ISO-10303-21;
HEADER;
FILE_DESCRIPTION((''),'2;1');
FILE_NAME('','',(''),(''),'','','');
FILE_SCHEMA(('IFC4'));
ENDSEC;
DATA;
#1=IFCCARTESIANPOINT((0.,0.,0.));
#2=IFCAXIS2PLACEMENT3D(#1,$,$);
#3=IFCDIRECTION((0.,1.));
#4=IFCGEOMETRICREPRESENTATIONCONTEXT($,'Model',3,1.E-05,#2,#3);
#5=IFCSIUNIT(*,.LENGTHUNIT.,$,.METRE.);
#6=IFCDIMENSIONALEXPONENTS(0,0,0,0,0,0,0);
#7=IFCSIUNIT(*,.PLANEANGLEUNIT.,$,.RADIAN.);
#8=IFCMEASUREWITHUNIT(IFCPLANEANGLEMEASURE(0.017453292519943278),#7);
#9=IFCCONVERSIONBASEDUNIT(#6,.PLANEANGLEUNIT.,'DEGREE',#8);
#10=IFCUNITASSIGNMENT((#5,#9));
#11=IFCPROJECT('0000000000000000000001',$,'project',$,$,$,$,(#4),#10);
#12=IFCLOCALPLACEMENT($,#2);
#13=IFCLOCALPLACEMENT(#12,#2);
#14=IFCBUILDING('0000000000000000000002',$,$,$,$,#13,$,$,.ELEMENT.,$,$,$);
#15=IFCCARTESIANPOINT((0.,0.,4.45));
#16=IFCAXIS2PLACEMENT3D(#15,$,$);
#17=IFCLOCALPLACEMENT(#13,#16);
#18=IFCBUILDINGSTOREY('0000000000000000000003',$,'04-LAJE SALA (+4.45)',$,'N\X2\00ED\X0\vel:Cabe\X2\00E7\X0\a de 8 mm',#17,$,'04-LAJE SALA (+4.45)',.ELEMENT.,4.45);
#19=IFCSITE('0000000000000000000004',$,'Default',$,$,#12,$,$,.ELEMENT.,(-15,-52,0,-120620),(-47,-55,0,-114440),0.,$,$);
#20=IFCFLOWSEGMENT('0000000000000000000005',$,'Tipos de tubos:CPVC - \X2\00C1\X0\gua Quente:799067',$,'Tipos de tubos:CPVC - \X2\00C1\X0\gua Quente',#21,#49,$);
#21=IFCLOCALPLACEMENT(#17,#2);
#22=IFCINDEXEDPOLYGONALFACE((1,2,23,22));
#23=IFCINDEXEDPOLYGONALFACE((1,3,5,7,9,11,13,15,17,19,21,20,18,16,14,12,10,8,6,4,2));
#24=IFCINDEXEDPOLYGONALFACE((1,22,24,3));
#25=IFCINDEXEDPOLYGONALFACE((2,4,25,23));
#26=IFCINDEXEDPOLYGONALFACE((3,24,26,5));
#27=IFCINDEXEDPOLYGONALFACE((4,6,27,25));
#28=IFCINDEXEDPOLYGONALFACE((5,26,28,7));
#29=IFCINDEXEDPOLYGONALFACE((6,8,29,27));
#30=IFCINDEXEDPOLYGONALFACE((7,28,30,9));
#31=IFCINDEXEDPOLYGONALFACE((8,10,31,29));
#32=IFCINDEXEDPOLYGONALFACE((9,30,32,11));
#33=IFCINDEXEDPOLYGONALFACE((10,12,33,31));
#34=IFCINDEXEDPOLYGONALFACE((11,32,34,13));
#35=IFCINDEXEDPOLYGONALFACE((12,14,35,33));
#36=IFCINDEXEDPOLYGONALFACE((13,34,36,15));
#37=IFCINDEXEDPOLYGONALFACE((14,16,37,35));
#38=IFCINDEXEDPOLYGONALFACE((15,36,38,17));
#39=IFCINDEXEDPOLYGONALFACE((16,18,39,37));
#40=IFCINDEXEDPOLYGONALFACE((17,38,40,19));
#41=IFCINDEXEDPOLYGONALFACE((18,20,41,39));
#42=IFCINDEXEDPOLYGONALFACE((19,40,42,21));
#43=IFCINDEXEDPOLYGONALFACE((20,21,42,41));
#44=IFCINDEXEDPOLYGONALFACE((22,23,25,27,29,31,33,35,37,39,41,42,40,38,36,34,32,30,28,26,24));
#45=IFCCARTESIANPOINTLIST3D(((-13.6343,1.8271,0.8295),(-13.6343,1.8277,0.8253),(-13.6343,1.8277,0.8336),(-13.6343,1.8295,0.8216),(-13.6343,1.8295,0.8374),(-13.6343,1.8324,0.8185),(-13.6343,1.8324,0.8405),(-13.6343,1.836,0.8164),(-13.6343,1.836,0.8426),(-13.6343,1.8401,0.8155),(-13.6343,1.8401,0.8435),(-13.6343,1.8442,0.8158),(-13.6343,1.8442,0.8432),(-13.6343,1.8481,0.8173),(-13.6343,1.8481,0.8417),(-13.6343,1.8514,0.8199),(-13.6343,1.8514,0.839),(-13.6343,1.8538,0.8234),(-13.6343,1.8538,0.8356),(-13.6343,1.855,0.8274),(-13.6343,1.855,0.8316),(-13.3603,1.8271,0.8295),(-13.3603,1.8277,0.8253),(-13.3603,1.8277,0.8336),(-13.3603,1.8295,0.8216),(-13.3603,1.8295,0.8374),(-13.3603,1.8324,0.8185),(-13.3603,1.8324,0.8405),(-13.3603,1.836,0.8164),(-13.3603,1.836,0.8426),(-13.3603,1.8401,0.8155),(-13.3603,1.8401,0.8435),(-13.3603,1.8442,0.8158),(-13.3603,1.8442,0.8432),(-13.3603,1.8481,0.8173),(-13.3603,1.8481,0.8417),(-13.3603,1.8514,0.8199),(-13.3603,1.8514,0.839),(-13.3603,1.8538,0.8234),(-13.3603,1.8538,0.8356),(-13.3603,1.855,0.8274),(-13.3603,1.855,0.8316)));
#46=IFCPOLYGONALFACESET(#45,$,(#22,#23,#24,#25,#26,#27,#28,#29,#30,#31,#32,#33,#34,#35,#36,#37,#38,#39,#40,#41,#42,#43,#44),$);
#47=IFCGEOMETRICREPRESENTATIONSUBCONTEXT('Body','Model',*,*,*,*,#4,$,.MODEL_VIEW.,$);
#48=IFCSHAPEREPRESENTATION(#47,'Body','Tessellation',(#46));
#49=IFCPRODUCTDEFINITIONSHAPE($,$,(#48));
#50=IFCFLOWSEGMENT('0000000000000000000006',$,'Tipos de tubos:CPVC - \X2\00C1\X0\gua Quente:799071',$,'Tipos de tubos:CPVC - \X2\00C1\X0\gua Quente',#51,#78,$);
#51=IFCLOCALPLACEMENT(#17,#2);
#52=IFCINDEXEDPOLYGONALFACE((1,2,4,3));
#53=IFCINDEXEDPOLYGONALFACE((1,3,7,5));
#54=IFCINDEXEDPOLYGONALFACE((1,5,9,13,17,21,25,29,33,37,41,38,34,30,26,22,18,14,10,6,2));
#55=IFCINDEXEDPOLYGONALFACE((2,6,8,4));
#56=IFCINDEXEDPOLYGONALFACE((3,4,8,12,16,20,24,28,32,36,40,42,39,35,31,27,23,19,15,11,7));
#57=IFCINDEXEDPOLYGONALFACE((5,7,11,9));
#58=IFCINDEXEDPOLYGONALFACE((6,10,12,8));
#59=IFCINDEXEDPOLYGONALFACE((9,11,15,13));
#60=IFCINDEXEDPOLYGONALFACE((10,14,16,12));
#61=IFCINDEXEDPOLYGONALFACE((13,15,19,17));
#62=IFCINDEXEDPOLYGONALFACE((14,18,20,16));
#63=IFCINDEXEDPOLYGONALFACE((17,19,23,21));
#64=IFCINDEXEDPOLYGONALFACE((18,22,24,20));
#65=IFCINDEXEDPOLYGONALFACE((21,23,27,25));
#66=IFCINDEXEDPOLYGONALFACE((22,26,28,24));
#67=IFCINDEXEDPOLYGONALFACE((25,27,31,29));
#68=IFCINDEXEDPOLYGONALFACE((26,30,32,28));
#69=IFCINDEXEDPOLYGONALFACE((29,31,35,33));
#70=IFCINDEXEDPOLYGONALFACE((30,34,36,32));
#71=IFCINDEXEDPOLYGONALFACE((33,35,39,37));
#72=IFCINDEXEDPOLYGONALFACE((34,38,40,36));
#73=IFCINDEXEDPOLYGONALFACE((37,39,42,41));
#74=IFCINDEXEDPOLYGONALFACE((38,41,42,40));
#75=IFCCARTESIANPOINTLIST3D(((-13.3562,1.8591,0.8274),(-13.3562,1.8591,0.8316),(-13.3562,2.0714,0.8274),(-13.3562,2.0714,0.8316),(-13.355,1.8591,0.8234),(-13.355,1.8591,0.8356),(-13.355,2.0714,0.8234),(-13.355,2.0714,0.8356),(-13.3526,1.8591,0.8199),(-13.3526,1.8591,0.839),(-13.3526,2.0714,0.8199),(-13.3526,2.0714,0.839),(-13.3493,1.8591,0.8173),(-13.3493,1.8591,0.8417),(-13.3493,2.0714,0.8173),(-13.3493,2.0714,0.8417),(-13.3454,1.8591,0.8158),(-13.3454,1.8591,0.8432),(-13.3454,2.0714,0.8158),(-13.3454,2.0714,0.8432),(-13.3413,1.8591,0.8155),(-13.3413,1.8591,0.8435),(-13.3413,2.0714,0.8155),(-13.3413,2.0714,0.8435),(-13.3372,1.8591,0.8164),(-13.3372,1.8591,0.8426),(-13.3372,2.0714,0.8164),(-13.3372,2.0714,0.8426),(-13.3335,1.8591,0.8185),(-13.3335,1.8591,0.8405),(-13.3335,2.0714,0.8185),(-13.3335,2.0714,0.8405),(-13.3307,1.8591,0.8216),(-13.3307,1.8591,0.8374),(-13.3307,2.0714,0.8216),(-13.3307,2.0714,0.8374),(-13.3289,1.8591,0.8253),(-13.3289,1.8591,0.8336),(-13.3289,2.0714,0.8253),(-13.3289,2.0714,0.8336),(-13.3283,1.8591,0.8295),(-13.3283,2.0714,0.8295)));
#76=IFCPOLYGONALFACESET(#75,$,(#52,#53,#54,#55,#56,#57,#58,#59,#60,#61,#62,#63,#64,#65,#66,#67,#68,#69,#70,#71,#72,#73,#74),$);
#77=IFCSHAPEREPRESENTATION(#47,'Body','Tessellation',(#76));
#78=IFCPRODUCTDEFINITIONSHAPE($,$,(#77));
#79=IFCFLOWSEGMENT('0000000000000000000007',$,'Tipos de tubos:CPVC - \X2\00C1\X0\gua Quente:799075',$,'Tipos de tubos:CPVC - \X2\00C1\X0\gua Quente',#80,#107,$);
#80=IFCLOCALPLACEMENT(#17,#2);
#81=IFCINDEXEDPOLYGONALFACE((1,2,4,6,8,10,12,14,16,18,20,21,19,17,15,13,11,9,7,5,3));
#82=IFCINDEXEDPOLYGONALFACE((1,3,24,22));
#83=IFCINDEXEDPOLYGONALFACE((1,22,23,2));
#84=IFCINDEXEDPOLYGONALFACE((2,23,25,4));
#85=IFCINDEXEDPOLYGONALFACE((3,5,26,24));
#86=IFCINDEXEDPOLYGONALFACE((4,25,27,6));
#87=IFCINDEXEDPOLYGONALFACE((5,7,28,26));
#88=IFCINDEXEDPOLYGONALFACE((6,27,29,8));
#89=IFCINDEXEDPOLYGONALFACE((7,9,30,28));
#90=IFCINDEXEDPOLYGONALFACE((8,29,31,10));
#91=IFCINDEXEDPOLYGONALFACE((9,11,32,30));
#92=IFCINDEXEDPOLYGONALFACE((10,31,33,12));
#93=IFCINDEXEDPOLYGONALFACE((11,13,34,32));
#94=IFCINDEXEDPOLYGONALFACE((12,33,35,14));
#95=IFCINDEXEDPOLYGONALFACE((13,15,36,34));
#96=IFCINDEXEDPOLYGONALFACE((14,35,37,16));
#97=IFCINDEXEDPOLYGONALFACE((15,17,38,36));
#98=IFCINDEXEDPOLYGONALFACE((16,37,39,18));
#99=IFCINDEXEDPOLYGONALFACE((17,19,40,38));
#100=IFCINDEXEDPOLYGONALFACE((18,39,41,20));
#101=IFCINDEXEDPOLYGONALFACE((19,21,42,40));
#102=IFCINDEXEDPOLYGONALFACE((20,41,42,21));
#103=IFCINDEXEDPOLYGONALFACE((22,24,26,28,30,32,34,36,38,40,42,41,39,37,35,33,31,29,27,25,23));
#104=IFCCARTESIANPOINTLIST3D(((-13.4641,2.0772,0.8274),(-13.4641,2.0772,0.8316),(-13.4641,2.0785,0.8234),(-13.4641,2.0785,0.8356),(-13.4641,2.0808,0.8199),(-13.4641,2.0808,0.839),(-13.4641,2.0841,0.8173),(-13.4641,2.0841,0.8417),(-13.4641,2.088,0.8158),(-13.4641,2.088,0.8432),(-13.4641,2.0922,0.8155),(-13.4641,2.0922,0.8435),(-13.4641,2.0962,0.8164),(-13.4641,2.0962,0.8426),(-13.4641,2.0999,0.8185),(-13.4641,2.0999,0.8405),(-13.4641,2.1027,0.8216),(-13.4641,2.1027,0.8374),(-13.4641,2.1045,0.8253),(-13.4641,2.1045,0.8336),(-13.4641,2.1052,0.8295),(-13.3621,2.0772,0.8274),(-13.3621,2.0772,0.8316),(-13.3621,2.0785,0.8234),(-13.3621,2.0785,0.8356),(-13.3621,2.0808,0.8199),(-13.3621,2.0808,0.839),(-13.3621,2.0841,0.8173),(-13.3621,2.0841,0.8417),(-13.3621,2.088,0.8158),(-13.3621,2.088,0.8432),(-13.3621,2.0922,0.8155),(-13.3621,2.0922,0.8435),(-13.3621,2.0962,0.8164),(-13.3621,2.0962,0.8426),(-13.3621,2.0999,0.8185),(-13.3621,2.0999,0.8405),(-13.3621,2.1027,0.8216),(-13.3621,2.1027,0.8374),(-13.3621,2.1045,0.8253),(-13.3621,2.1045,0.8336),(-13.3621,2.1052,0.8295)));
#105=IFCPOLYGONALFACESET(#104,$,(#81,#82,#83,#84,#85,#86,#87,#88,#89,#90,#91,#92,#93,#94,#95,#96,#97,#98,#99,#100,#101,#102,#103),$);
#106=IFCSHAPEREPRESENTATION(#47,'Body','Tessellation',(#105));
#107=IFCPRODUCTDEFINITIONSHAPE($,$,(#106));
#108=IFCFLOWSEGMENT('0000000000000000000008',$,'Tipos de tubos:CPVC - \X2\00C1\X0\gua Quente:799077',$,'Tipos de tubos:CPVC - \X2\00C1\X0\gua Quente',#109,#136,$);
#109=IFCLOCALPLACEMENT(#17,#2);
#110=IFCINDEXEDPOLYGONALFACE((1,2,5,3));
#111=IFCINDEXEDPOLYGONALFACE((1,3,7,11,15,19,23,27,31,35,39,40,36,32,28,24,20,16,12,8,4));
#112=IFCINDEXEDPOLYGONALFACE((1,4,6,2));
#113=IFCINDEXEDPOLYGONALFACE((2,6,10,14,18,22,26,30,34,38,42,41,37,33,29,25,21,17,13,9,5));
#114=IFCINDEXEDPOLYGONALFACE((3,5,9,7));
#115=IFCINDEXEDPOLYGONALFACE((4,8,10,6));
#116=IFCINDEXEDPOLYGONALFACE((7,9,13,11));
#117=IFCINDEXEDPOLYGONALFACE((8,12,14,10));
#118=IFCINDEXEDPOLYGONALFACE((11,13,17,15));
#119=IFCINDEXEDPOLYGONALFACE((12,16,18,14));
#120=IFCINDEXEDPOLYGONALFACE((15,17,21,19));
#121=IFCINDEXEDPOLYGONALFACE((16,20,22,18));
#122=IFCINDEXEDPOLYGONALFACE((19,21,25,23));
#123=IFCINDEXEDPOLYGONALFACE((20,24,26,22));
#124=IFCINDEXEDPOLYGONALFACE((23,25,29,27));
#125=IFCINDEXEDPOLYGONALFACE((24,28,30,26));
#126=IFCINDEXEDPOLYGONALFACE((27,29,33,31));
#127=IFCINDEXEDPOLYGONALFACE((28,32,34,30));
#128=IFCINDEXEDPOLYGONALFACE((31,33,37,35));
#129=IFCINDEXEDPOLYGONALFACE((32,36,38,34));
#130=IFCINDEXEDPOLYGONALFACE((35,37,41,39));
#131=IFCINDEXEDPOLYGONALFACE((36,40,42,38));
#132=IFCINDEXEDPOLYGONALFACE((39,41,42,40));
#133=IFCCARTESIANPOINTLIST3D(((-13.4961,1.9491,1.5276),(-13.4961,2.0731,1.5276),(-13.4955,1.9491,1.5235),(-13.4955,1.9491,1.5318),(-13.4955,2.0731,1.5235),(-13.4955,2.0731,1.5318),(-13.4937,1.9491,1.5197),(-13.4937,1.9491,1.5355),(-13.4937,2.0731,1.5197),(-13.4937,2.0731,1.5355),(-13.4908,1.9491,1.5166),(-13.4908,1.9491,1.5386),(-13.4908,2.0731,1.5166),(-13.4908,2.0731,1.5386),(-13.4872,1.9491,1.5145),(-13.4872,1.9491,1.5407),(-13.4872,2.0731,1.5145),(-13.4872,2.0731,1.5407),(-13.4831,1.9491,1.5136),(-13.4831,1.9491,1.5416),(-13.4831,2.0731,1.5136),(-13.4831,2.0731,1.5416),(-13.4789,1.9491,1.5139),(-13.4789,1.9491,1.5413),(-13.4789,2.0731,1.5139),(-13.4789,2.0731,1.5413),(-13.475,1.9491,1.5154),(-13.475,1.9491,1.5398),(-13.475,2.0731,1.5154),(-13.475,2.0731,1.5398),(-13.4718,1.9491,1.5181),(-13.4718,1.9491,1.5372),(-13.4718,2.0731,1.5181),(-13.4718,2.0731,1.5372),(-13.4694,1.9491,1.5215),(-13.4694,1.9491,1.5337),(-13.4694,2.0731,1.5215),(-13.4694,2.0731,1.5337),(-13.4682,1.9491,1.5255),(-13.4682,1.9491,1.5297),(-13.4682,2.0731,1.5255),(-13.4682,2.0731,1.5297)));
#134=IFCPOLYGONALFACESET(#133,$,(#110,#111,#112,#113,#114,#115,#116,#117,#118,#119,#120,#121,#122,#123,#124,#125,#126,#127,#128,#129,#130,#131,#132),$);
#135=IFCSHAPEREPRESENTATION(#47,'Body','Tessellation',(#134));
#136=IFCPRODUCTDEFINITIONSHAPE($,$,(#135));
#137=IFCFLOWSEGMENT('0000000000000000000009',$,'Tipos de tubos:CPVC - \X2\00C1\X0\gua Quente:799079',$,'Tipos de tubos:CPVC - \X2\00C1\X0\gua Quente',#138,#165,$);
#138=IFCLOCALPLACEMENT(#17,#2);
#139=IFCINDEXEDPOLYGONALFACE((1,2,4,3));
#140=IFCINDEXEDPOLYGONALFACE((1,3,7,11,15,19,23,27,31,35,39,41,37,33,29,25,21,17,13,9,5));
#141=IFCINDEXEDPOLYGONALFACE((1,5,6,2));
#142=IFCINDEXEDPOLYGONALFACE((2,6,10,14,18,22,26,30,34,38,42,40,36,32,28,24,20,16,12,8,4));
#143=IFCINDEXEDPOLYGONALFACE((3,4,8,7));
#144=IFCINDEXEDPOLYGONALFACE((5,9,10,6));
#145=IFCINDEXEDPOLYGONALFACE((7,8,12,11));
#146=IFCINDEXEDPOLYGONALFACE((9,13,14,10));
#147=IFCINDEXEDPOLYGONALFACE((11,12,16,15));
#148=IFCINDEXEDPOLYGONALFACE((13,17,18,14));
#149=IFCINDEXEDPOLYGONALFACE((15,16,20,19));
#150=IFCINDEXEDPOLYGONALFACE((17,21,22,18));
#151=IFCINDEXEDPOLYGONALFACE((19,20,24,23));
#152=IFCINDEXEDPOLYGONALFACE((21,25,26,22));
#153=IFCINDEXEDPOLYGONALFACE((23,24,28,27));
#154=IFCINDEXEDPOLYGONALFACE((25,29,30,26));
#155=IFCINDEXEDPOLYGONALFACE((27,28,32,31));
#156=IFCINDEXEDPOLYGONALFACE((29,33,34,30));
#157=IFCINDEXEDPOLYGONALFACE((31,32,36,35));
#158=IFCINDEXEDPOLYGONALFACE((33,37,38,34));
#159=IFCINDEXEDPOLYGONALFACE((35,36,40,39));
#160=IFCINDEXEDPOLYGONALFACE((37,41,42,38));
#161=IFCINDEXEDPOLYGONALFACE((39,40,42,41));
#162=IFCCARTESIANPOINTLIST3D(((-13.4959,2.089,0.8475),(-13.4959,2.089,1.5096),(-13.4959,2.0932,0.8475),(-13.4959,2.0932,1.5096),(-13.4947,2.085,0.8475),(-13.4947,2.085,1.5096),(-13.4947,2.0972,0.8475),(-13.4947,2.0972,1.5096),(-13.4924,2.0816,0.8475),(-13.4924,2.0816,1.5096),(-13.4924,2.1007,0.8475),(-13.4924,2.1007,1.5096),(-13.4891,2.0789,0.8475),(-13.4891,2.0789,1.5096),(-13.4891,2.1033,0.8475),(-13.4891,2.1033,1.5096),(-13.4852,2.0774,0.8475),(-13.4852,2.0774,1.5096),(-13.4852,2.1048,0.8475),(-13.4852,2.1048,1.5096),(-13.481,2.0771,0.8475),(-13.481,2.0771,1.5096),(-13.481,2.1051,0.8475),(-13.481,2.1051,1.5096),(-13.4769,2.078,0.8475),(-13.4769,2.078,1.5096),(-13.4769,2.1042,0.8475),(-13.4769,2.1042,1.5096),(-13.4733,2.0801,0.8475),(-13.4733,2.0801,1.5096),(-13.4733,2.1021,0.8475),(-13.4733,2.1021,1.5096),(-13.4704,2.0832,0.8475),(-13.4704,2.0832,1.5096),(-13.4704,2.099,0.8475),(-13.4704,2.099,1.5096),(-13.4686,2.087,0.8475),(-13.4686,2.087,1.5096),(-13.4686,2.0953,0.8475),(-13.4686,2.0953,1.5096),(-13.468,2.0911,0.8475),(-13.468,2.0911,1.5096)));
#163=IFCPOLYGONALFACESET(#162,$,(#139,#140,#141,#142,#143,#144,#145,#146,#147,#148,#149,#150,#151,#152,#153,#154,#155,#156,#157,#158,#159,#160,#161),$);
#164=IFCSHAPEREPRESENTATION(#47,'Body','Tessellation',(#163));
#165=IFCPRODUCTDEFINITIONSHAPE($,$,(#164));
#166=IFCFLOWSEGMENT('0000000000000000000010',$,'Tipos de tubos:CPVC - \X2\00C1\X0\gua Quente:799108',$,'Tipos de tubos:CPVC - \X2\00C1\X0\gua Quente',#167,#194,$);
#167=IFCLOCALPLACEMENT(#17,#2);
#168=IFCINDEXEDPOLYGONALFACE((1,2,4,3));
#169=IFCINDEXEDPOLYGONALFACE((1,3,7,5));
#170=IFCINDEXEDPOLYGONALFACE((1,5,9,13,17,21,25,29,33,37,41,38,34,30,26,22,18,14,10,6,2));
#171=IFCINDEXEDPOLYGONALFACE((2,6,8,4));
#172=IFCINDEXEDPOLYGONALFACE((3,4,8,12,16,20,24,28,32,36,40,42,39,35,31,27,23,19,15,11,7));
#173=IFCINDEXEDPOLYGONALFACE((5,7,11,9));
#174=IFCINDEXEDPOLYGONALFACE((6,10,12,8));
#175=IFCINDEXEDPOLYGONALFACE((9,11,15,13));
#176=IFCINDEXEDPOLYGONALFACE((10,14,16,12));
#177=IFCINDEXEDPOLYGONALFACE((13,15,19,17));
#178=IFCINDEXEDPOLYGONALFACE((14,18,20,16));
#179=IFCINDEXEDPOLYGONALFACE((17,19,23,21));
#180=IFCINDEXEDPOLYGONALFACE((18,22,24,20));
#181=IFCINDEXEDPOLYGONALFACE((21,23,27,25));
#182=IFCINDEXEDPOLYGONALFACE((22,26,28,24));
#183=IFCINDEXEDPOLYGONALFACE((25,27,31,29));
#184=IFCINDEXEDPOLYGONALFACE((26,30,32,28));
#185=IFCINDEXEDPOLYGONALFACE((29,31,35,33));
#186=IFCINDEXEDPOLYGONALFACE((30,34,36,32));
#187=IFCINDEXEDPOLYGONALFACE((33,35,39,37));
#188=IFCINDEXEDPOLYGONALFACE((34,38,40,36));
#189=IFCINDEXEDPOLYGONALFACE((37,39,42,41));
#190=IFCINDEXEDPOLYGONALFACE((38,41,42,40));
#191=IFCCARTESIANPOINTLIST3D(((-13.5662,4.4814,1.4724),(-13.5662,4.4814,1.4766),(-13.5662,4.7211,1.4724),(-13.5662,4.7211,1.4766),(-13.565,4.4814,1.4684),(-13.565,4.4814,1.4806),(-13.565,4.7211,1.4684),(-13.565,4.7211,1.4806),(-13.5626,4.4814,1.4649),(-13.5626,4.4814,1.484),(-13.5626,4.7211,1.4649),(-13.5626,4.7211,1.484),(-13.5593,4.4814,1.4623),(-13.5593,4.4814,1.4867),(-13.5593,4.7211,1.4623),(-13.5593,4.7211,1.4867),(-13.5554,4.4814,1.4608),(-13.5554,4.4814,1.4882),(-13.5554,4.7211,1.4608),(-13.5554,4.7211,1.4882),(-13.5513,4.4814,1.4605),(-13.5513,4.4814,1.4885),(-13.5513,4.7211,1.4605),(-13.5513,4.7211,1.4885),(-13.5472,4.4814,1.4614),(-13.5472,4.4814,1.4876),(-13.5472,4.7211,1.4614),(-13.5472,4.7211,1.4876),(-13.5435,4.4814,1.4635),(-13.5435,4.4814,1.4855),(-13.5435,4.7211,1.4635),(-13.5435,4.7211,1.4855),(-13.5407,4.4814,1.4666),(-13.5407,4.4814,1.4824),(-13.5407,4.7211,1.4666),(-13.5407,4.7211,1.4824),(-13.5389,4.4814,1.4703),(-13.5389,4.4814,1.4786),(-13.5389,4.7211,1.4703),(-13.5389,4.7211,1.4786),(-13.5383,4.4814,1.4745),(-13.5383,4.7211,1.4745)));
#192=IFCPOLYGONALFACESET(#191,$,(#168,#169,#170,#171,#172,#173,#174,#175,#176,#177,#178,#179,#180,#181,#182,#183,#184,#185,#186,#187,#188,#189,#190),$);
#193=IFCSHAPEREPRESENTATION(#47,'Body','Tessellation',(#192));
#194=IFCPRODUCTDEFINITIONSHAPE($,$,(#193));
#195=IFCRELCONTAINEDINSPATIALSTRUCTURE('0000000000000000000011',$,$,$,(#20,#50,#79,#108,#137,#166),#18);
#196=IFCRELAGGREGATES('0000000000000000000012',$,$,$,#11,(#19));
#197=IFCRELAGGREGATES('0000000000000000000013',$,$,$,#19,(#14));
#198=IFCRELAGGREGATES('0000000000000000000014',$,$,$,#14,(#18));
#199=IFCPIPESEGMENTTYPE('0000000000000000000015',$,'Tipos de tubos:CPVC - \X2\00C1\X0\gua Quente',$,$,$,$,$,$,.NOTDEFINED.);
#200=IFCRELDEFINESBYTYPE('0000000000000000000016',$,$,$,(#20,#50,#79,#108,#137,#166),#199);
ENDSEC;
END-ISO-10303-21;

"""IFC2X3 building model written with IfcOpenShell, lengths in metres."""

from ifc_helpers import new_model, entity, si_unit, converted_unit, direction, frame, frame_2d, origin, origin_2d_with_axis, place, context, subcontext, project, spatial, circle, extrude, type_object, element, save


model = new_model("IFC2X3")

# Units and contexts
model_context = context("Model", 3, precision=1e-05, world=origin(), true_north=direction((0.0, 1.0)))
body_context = subcontext(model_context, "Body", "Model", "MODEL_VIEW")
ifc_project = project(units=[si_unit("LENGTHUNIT", "METRE"), converted_unit("PLANEANGLEUNIT", "DEGREE", entity("IfcPlaneAngleMeasure", 0.017453292519943278), si_unit("PLANEANGLEUNIT", "RADIAN"), dimensions=[0, 0, 0, 0, 0, 0, 0])], contexts=[model_context])

# Site, building, storey
site_placement = place(None, origin())
site = spatial("IfcSite", under=ifc_project, at=site_placement, Name="Default", CompositionType="ELEMENT", RefLatitude=(-15, -52, 0, -120620), RefLongitude=(-47, -55, 0, -114440), RefElevation=0.0)
building_placement = place(site_placement, origin())
building = spatial("IfcBuilding", under=site, at=building_placement, CompositionType="ELEMENT")
storey_placement = place(building_placement, frame((0.0, 0.0, 4.45)))
storey = spatial("IfcBuildingStorey", under=building, at=storey_placement, Name="04-LAJE SALA (+4.45)", ObjectType="Nível:Cabeça de 8 mm", LongName="04-LAJE SALA (+4.45)", CompositionType="ELEMENT", Elevation=4.45)

# Flow segments
pipe_segment_type_1 = type_object("IfcPipeSegmentType", Name="Tipos de tubos:CPVC - Água Quente", PredefinedType="NOTDEFINED")
flow_segment_1_placement = place(storey_placement, origin())
element("IfcFlowSegment", 1, at=flow_segment_1_placement, inside=storey, type_object=pipe_segment_type_1, Name="Tipos de tubos:CPVC - Água Quente:799067", ObjectType="Tipos de tubos:CPVC - Água Quente", context=body_context, shape_type="SweptSolid", body=[
    extrude(circle(Radius=0.0141, at=frame_2d((0.0, 0.0), x_axis=(1.0, 0.0))), frame((-13.6343, 1.8411, 0.8295), z_axis=(1.0, 0.0, 0.0), x_axis=(0.0, -1.0, 0.0)), (0.0, 0.0, 1.0), 0.274),
])
flow_segment_2_placement = place(storey_placement, origin())
element("IfcFlowSegment", 2, at=flow_segment_2_placement, inside=storey, type_object=pipe_segment_type_1, Name="Tipos de tubos:CPVC - Água Quente:799071", ObjectType="Tipos de tubos:CPVC - Água Quente", context=body_context, shape_type="SweptSolid", body=[
    extrude(circle(Radius=0.0141, at=frame_2d((0.0, 0.0), x_axis=(1.0, 0.0))), frame((-13.3423, 1.8591, 0.8295), z_axis=(0.0, 1.0, 0.0), x_axis=(1.0, 0.0, 0.0)), (0.0, 0.0, 1.0), 0.2122),
])
flow_segment_3_placement = place(storey_placement, origin())
element("IfcFlowSegment", 3, at=flow_segment_3_placement, inside=storey, type_object=pipe_segment_type_1, Name="Tipos de tubos:CPVC - Água Quente:799075", ObjectType="Tipos de tubos:CPVC - Água Quente", context=body_context, shape_type="SweptSolid", body=[
    extrude(circle(Radius=0.0141, at=frame_2d((0.0, 0.0), x_axis=(1.0, 0.0))), frame((-13.4641, 2.0911, 0.8295), z_axis=(1.0, 0.0, 0.0), x_axis=(0.0, 1.0, 0.0)), (0.0, 0.0, 1.0), 0.102),
])
flow_segment_4_placement = place(storey_placement, origin())
element("IfcFlowSegment", 4, at=flow_segment_4_placement, inside=storey, type_object=pipe_segment_type_1, Name="Tipos de tubos:CPVC - Água Quente:799077", ObjectType="Tipos de tubos:CPVC - Água Quente", context=body_context, shape_type="SweptSolid", body=[
    extrude(circle(Radius=0.0141, at=origin_2d_with_axis()), frame((-13.4821, 1.9491, 1.5276), z_axis=(0.0, 1.0, 0.0), x_axis=(-1.0, 0.0, 0.0)), (0.0, 0.0, 1.0), 0.124),
])
flow_segment_5_placement = place(storey_placement, origin())
element("IfcFlowSegment", 5, at=flow_segment_5_placement, inside=storey, type_object=pipe_segment_type_1, Name="Tipos de tubos:CPVC - Água Quente:799079", ObjectType="Tipos de tubos:CPVC - Água Quente", context=body_context, shape_type="SweptSolid", body=[
    extrude(circle(Radius=0.0141, at=origin_2d_with_axis()), frame((-13.4821, 2.0911, 0.8475)), (0.0, 0.0, 1.0), 0.6621),
])
flow_segment_6_placement = place(storey_placement, origin())
element("IfcFlowSegment", 6, at=flow_segment_6_placement, inside=storey, type_object=pipe_segment_type_1, Name="Tipos de tubos:CPVC - Água Quente:799108", ObjectType="Tipos de tubos:CPVC - Água Quente", context=body_context, shape_type="SweptSolid", body=[
    extrude(circle(Radius=0.0141, at=frame_2d((0.0, 0.0), x_axis=(1.0, 0.0))), frame((-13.5523, 4.4814, 1.4745), z_axis=(0.0, 1.0, 0.0), x_axis=(1.0, 0.0, 0.0)), (0.0, 0.0, 1.0), 0.2397),
])

save(model, "model.ifc")
